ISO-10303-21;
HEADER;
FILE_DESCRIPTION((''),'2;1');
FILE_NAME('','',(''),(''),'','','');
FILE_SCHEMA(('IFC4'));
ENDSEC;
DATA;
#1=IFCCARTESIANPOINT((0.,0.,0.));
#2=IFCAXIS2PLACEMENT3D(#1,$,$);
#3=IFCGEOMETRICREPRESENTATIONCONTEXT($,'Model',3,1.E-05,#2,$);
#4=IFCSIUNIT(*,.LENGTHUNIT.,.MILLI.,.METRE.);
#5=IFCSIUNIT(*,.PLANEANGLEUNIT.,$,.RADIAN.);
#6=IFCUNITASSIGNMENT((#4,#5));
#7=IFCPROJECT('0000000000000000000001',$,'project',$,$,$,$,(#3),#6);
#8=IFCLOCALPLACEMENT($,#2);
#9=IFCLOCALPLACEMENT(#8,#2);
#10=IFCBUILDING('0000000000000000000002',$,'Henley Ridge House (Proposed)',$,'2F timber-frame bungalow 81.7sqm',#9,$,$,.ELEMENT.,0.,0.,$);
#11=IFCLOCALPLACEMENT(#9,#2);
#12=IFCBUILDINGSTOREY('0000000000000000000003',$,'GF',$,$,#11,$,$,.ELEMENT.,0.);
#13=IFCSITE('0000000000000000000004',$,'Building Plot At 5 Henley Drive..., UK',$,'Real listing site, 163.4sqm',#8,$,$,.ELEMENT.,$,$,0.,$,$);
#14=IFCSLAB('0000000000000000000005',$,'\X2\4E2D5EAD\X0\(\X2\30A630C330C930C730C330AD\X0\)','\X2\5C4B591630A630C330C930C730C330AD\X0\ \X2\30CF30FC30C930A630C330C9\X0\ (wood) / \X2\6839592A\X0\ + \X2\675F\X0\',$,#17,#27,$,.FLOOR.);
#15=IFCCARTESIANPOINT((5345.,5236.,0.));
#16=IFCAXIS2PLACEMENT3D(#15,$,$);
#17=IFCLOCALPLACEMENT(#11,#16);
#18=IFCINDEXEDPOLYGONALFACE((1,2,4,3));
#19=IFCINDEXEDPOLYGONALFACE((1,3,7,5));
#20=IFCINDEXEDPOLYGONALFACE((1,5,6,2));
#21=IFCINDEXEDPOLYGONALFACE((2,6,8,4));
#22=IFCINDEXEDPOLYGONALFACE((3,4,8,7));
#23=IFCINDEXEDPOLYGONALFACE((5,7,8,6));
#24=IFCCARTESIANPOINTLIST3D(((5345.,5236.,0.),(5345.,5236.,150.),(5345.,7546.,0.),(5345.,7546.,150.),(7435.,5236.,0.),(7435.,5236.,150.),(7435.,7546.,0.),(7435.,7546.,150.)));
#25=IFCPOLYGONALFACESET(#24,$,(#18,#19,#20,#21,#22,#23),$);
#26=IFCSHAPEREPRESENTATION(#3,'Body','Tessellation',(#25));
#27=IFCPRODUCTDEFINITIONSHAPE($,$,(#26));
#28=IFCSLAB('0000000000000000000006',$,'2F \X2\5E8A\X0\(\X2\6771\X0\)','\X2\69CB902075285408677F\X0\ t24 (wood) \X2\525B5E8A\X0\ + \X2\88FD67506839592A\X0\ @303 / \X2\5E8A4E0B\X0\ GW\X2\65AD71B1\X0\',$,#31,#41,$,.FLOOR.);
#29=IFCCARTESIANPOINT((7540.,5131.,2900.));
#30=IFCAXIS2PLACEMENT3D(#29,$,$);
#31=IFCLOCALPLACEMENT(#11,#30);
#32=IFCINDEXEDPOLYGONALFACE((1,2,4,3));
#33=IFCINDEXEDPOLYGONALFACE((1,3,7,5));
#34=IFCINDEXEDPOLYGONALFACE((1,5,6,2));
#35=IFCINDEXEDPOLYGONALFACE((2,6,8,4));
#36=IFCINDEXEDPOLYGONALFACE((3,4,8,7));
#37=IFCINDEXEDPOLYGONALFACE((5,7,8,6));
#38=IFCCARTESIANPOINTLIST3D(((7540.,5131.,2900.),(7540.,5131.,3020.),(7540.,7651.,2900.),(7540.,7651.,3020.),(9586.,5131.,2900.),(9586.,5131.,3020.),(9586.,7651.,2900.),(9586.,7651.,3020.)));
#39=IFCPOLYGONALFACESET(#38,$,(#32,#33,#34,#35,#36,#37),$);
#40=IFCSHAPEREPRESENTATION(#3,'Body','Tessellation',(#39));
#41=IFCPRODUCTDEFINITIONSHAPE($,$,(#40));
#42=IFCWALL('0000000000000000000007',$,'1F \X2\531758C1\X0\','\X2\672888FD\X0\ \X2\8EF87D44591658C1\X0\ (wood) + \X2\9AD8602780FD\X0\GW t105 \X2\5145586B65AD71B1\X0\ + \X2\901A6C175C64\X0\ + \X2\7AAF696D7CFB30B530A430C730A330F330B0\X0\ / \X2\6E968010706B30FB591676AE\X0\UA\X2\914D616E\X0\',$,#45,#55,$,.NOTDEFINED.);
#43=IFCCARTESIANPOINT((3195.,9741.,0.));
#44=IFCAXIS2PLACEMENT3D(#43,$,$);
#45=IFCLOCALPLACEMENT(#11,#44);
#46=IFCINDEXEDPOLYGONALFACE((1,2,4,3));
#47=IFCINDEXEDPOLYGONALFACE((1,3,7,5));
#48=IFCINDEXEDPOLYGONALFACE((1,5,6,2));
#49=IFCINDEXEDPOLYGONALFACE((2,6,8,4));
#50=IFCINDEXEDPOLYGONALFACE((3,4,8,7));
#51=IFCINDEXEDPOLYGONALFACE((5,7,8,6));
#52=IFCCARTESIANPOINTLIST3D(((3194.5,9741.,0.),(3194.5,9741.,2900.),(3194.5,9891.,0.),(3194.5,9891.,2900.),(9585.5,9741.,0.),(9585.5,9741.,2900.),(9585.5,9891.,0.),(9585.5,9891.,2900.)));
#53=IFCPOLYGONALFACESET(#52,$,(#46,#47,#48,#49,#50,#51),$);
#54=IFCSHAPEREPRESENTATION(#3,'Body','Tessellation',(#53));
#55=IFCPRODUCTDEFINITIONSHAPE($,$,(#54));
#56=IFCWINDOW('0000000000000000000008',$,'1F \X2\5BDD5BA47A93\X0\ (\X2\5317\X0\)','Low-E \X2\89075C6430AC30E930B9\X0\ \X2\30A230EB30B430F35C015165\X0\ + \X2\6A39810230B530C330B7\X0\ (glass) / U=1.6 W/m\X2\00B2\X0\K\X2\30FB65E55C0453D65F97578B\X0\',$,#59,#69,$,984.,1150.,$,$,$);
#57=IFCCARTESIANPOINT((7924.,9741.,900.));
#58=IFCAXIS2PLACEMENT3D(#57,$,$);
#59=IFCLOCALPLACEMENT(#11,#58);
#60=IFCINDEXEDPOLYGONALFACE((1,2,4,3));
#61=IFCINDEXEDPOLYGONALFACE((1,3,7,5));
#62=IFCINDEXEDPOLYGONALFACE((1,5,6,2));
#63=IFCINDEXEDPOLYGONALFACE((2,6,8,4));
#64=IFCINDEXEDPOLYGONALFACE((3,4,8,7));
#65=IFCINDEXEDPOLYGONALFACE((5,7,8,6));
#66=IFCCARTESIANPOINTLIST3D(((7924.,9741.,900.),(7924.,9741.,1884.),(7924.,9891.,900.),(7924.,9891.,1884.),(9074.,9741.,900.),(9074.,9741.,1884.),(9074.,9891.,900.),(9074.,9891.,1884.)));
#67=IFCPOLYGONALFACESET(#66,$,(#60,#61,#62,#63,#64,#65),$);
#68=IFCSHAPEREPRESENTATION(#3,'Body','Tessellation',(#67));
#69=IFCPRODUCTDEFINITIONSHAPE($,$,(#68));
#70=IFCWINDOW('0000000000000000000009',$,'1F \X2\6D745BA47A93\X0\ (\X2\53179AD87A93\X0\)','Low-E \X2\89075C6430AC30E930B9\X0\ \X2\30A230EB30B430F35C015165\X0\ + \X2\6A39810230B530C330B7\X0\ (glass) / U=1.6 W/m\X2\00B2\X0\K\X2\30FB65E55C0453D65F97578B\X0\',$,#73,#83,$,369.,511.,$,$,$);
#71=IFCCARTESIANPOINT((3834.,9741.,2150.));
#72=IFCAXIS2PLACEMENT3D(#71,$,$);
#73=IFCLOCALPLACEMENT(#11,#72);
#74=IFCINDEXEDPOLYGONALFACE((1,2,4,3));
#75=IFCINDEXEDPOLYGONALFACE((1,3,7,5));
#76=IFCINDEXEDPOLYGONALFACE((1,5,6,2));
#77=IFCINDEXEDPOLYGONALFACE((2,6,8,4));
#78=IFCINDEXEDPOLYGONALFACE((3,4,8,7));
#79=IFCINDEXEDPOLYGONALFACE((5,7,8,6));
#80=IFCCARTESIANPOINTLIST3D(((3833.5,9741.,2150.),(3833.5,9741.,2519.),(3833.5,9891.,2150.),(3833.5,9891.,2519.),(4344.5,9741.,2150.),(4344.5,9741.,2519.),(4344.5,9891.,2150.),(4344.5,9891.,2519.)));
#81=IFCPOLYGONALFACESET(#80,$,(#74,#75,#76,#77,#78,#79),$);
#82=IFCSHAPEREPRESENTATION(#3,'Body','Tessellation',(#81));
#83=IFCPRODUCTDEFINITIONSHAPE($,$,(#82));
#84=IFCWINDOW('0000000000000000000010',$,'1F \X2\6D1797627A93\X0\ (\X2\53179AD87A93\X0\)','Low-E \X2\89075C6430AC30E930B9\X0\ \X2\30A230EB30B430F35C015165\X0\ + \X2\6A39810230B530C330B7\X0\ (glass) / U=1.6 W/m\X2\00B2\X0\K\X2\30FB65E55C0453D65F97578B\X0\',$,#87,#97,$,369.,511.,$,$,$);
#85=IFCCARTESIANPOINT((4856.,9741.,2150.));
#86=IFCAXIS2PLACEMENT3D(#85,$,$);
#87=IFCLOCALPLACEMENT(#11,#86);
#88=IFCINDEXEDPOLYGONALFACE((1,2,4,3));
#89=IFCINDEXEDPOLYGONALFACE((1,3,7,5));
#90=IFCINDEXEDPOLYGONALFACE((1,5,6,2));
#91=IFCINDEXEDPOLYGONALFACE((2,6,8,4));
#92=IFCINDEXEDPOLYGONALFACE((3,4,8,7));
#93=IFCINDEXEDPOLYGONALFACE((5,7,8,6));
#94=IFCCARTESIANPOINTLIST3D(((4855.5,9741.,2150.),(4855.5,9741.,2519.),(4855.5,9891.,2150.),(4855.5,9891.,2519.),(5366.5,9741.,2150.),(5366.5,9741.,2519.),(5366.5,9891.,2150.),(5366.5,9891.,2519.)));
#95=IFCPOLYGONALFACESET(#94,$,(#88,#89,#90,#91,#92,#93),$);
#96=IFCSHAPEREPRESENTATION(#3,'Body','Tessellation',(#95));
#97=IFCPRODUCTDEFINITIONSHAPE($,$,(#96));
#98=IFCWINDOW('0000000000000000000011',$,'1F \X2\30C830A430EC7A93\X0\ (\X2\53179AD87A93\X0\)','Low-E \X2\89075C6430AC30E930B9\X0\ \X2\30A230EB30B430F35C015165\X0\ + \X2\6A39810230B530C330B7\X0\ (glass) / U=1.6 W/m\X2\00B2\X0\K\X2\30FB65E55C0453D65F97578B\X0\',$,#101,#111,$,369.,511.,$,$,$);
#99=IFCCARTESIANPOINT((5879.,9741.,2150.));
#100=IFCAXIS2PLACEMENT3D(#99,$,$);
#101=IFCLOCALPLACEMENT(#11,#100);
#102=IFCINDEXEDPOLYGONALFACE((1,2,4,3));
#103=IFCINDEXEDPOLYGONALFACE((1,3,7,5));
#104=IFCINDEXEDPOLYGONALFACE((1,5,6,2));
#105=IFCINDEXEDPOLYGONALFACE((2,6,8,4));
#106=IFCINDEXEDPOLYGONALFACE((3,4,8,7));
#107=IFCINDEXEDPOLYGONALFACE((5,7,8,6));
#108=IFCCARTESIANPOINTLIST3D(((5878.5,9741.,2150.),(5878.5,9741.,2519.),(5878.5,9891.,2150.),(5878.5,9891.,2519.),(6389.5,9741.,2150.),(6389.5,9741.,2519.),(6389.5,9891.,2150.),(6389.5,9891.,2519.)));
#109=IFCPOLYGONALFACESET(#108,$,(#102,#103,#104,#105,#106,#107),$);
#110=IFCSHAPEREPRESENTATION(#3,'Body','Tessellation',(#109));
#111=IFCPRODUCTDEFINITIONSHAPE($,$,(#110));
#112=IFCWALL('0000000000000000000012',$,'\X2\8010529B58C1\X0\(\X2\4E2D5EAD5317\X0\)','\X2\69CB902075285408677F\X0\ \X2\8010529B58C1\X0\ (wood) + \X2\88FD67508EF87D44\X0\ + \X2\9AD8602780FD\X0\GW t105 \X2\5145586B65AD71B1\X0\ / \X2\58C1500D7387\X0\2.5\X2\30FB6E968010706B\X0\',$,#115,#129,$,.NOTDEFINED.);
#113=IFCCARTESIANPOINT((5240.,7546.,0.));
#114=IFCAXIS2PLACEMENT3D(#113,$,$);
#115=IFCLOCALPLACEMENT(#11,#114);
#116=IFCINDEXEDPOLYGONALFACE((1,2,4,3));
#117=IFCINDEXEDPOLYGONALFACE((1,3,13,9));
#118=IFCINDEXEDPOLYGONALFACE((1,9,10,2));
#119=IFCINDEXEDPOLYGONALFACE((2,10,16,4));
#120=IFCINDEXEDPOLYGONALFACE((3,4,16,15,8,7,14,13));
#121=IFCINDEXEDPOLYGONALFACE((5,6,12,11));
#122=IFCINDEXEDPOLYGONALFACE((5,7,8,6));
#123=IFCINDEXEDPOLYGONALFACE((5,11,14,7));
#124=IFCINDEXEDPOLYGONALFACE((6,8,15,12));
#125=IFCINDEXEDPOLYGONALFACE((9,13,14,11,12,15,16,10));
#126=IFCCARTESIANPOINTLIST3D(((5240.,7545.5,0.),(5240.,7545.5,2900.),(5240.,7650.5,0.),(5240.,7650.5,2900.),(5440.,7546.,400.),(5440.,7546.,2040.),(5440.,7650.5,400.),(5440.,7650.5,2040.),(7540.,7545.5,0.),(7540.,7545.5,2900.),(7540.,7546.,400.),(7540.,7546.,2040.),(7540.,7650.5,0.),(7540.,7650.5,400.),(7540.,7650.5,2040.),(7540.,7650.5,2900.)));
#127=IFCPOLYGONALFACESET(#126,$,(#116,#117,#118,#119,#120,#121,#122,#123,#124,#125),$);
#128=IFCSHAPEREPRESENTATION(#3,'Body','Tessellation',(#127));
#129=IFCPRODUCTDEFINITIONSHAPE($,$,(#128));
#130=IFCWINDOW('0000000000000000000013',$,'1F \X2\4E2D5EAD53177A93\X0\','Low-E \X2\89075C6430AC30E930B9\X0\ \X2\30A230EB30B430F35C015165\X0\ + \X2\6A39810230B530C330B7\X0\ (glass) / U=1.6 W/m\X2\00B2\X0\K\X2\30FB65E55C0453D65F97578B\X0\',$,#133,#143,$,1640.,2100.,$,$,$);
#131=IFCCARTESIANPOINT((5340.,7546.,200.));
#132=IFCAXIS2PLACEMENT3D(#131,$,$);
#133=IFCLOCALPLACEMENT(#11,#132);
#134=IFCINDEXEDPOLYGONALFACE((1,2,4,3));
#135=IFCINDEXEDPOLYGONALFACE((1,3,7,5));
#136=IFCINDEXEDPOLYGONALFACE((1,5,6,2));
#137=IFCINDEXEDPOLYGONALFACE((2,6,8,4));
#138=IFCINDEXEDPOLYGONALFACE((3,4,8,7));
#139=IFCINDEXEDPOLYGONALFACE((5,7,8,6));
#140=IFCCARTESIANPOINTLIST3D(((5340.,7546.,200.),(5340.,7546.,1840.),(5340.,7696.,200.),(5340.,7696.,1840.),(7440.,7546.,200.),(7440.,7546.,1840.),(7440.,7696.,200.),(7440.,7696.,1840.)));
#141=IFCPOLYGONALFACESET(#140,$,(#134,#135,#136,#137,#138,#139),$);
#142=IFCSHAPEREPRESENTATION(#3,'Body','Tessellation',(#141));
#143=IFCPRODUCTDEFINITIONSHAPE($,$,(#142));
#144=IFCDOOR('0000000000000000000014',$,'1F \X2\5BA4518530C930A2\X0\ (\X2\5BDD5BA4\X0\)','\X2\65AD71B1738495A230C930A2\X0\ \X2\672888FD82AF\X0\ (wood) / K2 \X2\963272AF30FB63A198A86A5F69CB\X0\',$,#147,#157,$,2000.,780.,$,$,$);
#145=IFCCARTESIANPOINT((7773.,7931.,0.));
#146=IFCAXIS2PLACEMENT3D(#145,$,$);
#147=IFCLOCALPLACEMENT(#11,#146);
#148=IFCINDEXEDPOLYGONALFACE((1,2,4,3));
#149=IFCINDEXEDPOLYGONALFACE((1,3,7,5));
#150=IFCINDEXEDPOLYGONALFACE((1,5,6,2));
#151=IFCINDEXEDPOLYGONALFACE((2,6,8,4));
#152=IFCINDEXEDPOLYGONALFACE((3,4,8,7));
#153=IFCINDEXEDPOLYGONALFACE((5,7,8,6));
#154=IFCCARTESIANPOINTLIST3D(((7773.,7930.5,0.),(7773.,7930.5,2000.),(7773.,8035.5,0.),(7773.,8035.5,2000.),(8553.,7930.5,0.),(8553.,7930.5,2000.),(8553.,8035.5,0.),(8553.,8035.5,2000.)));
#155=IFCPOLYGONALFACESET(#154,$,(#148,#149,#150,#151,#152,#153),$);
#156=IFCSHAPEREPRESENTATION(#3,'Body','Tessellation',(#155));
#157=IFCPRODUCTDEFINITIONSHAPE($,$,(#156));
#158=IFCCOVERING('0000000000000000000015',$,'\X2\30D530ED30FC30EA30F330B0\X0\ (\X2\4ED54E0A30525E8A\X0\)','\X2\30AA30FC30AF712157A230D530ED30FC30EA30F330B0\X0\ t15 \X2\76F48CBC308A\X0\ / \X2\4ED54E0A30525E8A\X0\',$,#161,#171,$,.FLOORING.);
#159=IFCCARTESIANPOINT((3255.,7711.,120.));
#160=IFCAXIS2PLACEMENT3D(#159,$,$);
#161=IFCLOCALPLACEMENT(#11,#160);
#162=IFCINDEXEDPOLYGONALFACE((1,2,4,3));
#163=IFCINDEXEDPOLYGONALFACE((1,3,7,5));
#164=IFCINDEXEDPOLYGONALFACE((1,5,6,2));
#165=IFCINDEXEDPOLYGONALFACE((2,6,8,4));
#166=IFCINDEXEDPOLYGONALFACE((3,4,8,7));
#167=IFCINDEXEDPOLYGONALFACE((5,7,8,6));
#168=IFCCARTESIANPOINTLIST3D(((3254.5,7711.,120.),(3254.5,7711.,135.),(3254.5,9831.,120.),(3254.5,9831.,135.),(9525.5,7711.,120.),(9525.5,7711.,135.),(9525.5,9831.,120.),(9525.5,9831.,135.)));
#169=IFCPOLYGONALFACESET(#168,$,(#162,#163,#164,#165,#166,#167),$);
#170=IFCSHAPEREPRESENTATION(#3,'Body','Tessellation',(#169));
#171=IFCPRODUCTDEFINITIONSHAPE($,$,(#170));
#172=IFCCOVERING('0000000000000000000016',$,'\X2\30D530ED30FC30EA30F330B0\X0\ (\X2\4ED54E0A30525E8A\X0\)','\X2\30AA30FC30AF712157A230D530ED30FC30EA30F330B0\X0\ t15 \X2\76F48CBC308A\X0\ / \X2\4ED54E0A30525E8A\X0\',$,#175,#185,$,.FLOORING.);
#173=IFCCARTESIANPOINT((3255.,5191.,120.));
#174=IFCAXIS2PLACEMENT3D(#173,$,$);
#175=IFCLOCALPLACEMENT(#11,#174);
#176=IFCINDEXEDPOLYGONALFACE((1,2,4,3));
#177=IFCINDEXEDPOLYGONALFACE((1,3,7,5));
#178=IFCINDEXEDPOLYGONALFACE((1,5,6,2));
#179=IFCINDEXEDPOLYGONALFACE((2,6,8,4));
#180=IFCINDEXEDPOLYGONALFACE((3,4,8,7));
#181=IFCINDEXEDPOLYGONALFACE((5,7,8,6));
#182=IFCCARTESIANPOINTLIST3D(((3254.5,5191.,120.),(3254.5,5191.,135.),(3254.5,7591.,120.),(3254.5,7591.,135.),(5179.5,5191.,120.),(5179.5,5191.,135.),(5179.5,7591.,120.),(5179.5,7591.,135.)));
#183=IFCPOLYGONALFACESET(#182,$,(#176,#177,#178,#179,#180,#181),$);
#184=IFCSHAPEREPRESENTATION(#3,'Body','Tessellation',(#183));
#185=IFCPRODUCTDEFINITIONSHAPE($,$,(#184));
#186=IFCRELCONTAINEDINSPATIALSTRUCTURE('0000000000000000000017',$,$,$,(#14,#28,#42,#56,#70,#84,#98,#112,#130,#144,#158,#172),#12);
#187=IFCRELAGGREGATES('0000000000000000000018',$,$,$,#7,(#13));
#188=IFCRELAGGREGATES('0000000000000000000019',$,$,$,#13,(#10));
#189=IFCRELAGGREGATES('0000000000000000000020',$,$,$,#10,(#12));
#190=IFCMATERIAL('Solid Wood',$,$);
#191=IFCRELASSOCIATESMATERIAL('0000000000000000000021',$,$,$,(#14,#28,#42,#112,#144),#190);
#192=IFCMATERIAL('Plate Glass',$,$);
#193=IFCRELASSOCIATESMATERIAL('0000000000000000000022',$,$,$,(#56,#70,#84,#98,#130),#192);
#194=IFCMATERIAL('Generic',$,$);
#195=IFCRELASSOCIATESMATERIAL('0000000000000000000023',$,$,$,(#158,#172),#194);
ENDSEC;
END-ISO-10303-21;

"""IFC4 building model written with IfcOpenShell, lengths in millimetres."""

from ifc_helpers import new_model, si_unit, frame, frame_2d, origin, place, context, project, spatial, rectangle, extrude, material, element, fill, save


model = new_model("IFC4")

# Units and contexts
model_context = context("Model", 3, precision=1e-05, world=origin())
ifc_project = project(units=[si_unit("LENGTHUNIT", "METRE", prefix="MILLI"), si_unit("PLANEANGLEUNIT", "RADIAN")], contexts=[model_context])

# Site, building, storey
site_placement = place(None, origin())
site = spatial("IfcSite", under=ifc_project, at=site_placement, Name="Building Plot At 5 Henley Drive..., UK", ObjectType="Real listing site, 163.4sqm", CompositionType="ELEMENT", RefElevation=0.0)
building_placement = place(site_placement, origin())
building = spatial("IfcBuilding", under=site, at=building_placement, Name="Henley Ridge House (Proposed)", ObjectType="2F timber-frame bungalow 81.7sqm", CompositionType="ELEMENT", ElevationOfRefHeight=0.0, ElevationOfTerrain=0.0)
storey_placement = place(building_placement, origin())
storey = spatial("IfcBuildingStorey", under=building, at=storey_placement, Name="GF", CompositionType="ELEMENT", Elevation=0.0)

# Slabs
ifc_material_1 = material(Name="Solid Wood")
slab_1_placement = place(storey_placement, frame((5345.0, 5236.0, 0.0)))
element("IfcSlab", 1, at=slab_1_placement, inside=storey, material=ifc_material_1, Name="中庭(ウッドデッキ)", Description="屋外ウッドデッキ ハードウッド (wood) / 根太 + 束", PredefinedType="FLOOR", context=model_context, shape_type="SweptSolid", body=[
    extrude(rectangle(XDim=2090.0, YDim=2310.0, at=frame_2d((1045.0, 1155.0))), frame((5345.0, 5236.0, 0.0)), (0.0, 0.0, 1.0), 150.0),
])
slab_2_placement = place(storey_placement, frame((7540.0, 5131.0, 2900.0)))
element("IfcSlab", 2, at=slab_2_placement, inside=storey, material=ifc_material_1, Name="2F 床(東)", Description="構造用合板 t24 (wood) 剛床 + 製材根太 @303 / 床下 GW断熱", PredefinedType="FLOOR", context=model_context, shape_type="SweptSolid", body=[
    extrude(rectangle(XDim=2046.0, YDim=2520.0, at=frame_2d((1023.0, 1260.0))), frame((7540.0, 5131.0, 2900.0)), (0.0, 0.0, 1.0), 120.0),
])

# Wall, openings, windows
wall_1_placement = place(storey_placement, frame((3195.0, 9741.0, 0.0)))
wall_1 = element("IfcWall", 3, at=wall_1_placement, inside=storey, material=ifc_material_1, Name="1F 北壁", Description="木製 軸組外壁 (wood) + 高性能GW t105 充填断熱 + 通気層 + 窯業系サイディング / 準耐火・外皮UA配慮", PredefinedType="NOTDEFINED", context=model_context, shape_type="SweptSolid", body=[
    extrude(rectangle(XDim=6391.0, YDim=150.0, at=frame_2d((3195.0, 75.0))), frame((3195.0, 9741.0, 0.0)), (0.0, 0.0, 1.0), 2900.0),
])
opening_1_placement = place(storey_placement, frame((7924.0, 9741.0, 900.0)))
opening_1 = element("IfcOpeningElement", 4, at=opening_1_placement, cuts=wall_1, PredefinedType="NOTDEFINED", context=model_context, shape_type="SweptSolid", body=[
    extrude(rectangle(XDim=1150.0, YDim=150.0, at=frame_2d((575.0, 75.0))), frame((7924.0, 9741.0, 900.0)), (0.0, 0.0, 1.0), 984.0),
])
opening_2_placement = place(storey_placement, frame((3834.0, 9741.0, 2150.0)))
opening_2 = element("IfcOpeningElement", 5, at=opening_2_placement, cuts=wall_1, PredefinedType="NOTDEFINED", context=model_context, shape_type="SweptSolid", body=[
    extrude(rectangle(XDim=511.0, YDim=150.0, at=frame_2d((255.0, 75.0))), frame((3834.0, 9741.0, 2150.0)), (0.0, 0.0, 1.0), 369.0),
])
opening_3_placement = place(storey_placement, frame((4856.0, 9741.0, 2150.0)))
opening_3 = element("IfcOpeningElement", 6, at=opening_3_placement, cuts=wall_1, PredefinedType="NOTDEFINED", context=model_context, shape_type="SweptSolid", body=[
    extrude(rectangle(XDim=511.0, YDim=150.0, at=frame_2d((255.0, 75.0))), frame((4856.0, 9741.0, 2150.0)), (0.0, 0.0, 1.0), 369.0),
])
opening_4_placement = place(storey_placement, frame((5879.0, 9741.0, 2150.0)))
opening_4 = element("IfcOpeningElement", 7, at=opening_4_placement, cuts=wall_1, PredefinedType="NOTDEFINED", context=model_context, shape_type="SweptSolid", body=[
    extrude(rectangle(XDim=511.0, YDim=150.0, at=frame_2d((255.0, 75.0))), frame((5879.0, 9741.0, 2150.0)), (0.0, 0.0, 1.0), 369.0),
])
ifc_material_2 = material(Name="Plate Glass")
window_1_placement = place(storey_placement, frame((7924.0, 9741.0, 900.0)))
window_1 = element("IfcWindow", 8, at=window_1_placement, inside=storey, material=ifc_material_2, Name="1F 寝室窓 (北)", Description="Low-E 複層ガラス アルゴン封入 + 樹脂サッシ (glass) / U=1.6 W/m²K・日射取得型", OverallHeight=984.0, OverallWidth=1150.0, context=model_context, shape_type="SweptSolid", body=[
    extrude(rectangle(XDim=1150.0, YDim=150.0, at=frame_2d((575.0, 75.0))), frame((7924.0, 9741.0, 900.0)), (0.0, 0.0, 1.0), 984.0),
])
fill(opening_1, window_1)
window_2_placement = place(storey_placement, frame((3834.0, 9741.0, 2150.0)))
window_2 = element("IfcWindow", 9, at=window_2_placement, inside=storey, material=ifc_material_2, Name="1F 浴室窓 (北高窓)", Description="Low-E 複層ガラス アルゴン封入 + 樹脂サッシ (glass) / U=1.6 W/m²K・日射取得型", OverallHeight=369.0, OverallWidth=511.0, context=model_context, shape_type="SweptSolid", body=[
    extrude(rectangle(XDim=511.0, YDim=150.0, at=frame_2d((255.0, 75.0))), frame((3834.0, 9741.0, 2150.0)), (0.0, 0.0, 1.0), 369.0),
])
fill(opening_2, window_2)
window_3_placement = place(storey_placement, frame((4856.0, 9741.0, 2150.0)))
window_3 = element("IfcWindow", 10, at=window_3_placement, inside=storey, material=ifc_material_2, Name="1F 洗面窓 (北高窓)", Description="Low-E 複層ガラス アルゴン封入 + 樹脂サッシ (glass) / U=1.6 W/m²K・日射取得型", OverallHeight=369.0, OverallWidth=511.0, context=model_context, shape_type="SweptSolid", body=[
    extrude(rectangle(XDim=511.0, YDim=150.0, at=frame_2d((255.0, 75.0))), frame((4856.0, 9741.0, 2150.0)), (0.0, 0.0, 1.0), 369.0),
])
fill(opening_3, window_3)
window_4_placement = place(storey_placement, frame((5879.0, 9741.0, 2150.0)))
window_4 = element("IfcWindow", 11, at=window_4_placement, inside=storey, material=ifc_material_2, Name="1F トイレ窓 (北高窓)", Description="Low-E 複層ガラス アルゴン封入 + 樹脂サッシ (glass) / U=1.6 W/m²K・日射取得型", OverallHeight=369.0, OverallWidth=511.0, context=model_context, shape_type="SweptSolid", body=[
    extrude(rectangle(XDim=511.0, YDim=150.0, at=frame_2d((255.0, 75.0))), frame((5879.0, 9741.0, 2150.0)), (0.0, 0.0, 1.0), 369.0),
])
fill(opening_4, window_4)

# Wall, opening, window
wall_2_placement = place(storey_placement, frame((5240.0, 7546.0, 0.0)))
wall_2 = element("IfcWall", 12, at=wall_2_placement, inside=storey, material=ifc_material_1, Name="耐力壁(中庭北)", Description="構造用合板 耐力壁 (wood) + 製材軸組 + 高性能GW t105 充填断熱 / 壁倍率2.5・準耐火", PredefinedType="NOTDEFINED", context=model_context, shape_type="SweptSolid", body=[
    extrude(rectangle(XDim=2300.0, YDim=105.0, at=frame_2d((1150.0, 52.0))), frame((5240.0, 7546.0, 0.0)), (0.0, 0.0, 1.0), 2900.0),
])
opening_5_placement = place(storey_placement, frame((5340.0, 7546.0, 200.0)))
opening_5 = element("IfcOpeningElement", 13, at=opening_5_placement, cuts=wall_2, PredefinedType="NOTDEFINED", context=model_context, shape_type="SweptSolid", body=[
    extrude(rectangle(XDim=2100.0, YDim=150.0, at=frame_2d((1050.0, 75.0))), frame((5340.0, 7546.0, 200.0)), (0.0, 0.0, 1.0), 1640.0),
])
window_5_placement = place(storey_placement, frame((5340.0, 7546.0, 200.0)))
window_5 = element("IfcWindow", 14, at=window_5_placement, inside=storey, material=ifc_material_2, Name="1F 中庭北窓", Description="Low-E 複層ガラス アルゴン封入 + 樹脂サッシ (glass) / U=1.6 W/m²K・日射取得型", OverallHeight=1640.0, OverallWidth=2100.0, context=model_context, shape_type="SweptSolid", body=[
    extrude(rectangle(XDim=2100.0, YDim=150.0, at=frame_2d((1050.0, 75.0))), frame((5340.0, 7546.0, 200.0)), (0.0, 0.0, 1.0), 1640.0),
])
fill(opening_5, window_5)

# Door
door_1_placement = place(storey_placement, frame((7773.0, 7931.0, 0.0)))
element("IfcDoor", 15, at=door_1_placement, inside=storey, material=ifc_material_1, Name="1F 室内ドア (寝室)", Description="断熱玄関ドア 木製芯 (wood) / K2 防犯・採風機構", OverallHeight=2000.0, OverallWidth=780.0, context=model_context, shape_type="SweptSolid", body=[
    extrude(rectangle(XDim=780.0, YDim=105.0, at=frame_2d((390.0, 52.0))), frame((7773.0, 7931.0, 0.0)), (0.0, 0.0, 1.0), 2000.0),
])

# Coverings
ifc_material_3 = material(Name="Generic")
covering_1_placement = place(storey_placement, frame((3255.0, 7711.0, 120.0)))
element("IfcCovering", 16, at=covering_1_placement, inside=storey, material=ifc_material_3, Name="フローリング (仕上げ床)", Description="オーク無垢フローリング t15 直貼り / 仕上げ床", PredefinedType="FLOORING", context=model_context, shape_type="SweptSolid", body=[
    extrude(rectangle(XDim=6271.0, YDim=2120.0, at=frame_2d((3135.0, 1060.0))), frame((3255.0, 7711.0, 120.0)), (0.0, 0.0, 1.0), 15.0),
])
covering_2_placement = place(storey_placement, frame((3255.0, 5191.0, 120.0)))
element("IfcCovering", 17, at=covering_2_placement, inside=storey, material=ifc_material_3, Name="フローリング (仕上げ床)", Description="オーク無垢フローリング t15 直貼り / 仕上げ床", PredefinedType="FLOORING", context=model_context, shape_type="SweptSolid", body=[
    extrude(rectangle(XDim=1925.0, YDim=2400.0, at=frame_2d((962.0, 1200.0))), frame((3255.0, 5191.0, 120.0)), (0.0, 0.0, 1.0), 15.0),
])

save(model, "model.ifc")
